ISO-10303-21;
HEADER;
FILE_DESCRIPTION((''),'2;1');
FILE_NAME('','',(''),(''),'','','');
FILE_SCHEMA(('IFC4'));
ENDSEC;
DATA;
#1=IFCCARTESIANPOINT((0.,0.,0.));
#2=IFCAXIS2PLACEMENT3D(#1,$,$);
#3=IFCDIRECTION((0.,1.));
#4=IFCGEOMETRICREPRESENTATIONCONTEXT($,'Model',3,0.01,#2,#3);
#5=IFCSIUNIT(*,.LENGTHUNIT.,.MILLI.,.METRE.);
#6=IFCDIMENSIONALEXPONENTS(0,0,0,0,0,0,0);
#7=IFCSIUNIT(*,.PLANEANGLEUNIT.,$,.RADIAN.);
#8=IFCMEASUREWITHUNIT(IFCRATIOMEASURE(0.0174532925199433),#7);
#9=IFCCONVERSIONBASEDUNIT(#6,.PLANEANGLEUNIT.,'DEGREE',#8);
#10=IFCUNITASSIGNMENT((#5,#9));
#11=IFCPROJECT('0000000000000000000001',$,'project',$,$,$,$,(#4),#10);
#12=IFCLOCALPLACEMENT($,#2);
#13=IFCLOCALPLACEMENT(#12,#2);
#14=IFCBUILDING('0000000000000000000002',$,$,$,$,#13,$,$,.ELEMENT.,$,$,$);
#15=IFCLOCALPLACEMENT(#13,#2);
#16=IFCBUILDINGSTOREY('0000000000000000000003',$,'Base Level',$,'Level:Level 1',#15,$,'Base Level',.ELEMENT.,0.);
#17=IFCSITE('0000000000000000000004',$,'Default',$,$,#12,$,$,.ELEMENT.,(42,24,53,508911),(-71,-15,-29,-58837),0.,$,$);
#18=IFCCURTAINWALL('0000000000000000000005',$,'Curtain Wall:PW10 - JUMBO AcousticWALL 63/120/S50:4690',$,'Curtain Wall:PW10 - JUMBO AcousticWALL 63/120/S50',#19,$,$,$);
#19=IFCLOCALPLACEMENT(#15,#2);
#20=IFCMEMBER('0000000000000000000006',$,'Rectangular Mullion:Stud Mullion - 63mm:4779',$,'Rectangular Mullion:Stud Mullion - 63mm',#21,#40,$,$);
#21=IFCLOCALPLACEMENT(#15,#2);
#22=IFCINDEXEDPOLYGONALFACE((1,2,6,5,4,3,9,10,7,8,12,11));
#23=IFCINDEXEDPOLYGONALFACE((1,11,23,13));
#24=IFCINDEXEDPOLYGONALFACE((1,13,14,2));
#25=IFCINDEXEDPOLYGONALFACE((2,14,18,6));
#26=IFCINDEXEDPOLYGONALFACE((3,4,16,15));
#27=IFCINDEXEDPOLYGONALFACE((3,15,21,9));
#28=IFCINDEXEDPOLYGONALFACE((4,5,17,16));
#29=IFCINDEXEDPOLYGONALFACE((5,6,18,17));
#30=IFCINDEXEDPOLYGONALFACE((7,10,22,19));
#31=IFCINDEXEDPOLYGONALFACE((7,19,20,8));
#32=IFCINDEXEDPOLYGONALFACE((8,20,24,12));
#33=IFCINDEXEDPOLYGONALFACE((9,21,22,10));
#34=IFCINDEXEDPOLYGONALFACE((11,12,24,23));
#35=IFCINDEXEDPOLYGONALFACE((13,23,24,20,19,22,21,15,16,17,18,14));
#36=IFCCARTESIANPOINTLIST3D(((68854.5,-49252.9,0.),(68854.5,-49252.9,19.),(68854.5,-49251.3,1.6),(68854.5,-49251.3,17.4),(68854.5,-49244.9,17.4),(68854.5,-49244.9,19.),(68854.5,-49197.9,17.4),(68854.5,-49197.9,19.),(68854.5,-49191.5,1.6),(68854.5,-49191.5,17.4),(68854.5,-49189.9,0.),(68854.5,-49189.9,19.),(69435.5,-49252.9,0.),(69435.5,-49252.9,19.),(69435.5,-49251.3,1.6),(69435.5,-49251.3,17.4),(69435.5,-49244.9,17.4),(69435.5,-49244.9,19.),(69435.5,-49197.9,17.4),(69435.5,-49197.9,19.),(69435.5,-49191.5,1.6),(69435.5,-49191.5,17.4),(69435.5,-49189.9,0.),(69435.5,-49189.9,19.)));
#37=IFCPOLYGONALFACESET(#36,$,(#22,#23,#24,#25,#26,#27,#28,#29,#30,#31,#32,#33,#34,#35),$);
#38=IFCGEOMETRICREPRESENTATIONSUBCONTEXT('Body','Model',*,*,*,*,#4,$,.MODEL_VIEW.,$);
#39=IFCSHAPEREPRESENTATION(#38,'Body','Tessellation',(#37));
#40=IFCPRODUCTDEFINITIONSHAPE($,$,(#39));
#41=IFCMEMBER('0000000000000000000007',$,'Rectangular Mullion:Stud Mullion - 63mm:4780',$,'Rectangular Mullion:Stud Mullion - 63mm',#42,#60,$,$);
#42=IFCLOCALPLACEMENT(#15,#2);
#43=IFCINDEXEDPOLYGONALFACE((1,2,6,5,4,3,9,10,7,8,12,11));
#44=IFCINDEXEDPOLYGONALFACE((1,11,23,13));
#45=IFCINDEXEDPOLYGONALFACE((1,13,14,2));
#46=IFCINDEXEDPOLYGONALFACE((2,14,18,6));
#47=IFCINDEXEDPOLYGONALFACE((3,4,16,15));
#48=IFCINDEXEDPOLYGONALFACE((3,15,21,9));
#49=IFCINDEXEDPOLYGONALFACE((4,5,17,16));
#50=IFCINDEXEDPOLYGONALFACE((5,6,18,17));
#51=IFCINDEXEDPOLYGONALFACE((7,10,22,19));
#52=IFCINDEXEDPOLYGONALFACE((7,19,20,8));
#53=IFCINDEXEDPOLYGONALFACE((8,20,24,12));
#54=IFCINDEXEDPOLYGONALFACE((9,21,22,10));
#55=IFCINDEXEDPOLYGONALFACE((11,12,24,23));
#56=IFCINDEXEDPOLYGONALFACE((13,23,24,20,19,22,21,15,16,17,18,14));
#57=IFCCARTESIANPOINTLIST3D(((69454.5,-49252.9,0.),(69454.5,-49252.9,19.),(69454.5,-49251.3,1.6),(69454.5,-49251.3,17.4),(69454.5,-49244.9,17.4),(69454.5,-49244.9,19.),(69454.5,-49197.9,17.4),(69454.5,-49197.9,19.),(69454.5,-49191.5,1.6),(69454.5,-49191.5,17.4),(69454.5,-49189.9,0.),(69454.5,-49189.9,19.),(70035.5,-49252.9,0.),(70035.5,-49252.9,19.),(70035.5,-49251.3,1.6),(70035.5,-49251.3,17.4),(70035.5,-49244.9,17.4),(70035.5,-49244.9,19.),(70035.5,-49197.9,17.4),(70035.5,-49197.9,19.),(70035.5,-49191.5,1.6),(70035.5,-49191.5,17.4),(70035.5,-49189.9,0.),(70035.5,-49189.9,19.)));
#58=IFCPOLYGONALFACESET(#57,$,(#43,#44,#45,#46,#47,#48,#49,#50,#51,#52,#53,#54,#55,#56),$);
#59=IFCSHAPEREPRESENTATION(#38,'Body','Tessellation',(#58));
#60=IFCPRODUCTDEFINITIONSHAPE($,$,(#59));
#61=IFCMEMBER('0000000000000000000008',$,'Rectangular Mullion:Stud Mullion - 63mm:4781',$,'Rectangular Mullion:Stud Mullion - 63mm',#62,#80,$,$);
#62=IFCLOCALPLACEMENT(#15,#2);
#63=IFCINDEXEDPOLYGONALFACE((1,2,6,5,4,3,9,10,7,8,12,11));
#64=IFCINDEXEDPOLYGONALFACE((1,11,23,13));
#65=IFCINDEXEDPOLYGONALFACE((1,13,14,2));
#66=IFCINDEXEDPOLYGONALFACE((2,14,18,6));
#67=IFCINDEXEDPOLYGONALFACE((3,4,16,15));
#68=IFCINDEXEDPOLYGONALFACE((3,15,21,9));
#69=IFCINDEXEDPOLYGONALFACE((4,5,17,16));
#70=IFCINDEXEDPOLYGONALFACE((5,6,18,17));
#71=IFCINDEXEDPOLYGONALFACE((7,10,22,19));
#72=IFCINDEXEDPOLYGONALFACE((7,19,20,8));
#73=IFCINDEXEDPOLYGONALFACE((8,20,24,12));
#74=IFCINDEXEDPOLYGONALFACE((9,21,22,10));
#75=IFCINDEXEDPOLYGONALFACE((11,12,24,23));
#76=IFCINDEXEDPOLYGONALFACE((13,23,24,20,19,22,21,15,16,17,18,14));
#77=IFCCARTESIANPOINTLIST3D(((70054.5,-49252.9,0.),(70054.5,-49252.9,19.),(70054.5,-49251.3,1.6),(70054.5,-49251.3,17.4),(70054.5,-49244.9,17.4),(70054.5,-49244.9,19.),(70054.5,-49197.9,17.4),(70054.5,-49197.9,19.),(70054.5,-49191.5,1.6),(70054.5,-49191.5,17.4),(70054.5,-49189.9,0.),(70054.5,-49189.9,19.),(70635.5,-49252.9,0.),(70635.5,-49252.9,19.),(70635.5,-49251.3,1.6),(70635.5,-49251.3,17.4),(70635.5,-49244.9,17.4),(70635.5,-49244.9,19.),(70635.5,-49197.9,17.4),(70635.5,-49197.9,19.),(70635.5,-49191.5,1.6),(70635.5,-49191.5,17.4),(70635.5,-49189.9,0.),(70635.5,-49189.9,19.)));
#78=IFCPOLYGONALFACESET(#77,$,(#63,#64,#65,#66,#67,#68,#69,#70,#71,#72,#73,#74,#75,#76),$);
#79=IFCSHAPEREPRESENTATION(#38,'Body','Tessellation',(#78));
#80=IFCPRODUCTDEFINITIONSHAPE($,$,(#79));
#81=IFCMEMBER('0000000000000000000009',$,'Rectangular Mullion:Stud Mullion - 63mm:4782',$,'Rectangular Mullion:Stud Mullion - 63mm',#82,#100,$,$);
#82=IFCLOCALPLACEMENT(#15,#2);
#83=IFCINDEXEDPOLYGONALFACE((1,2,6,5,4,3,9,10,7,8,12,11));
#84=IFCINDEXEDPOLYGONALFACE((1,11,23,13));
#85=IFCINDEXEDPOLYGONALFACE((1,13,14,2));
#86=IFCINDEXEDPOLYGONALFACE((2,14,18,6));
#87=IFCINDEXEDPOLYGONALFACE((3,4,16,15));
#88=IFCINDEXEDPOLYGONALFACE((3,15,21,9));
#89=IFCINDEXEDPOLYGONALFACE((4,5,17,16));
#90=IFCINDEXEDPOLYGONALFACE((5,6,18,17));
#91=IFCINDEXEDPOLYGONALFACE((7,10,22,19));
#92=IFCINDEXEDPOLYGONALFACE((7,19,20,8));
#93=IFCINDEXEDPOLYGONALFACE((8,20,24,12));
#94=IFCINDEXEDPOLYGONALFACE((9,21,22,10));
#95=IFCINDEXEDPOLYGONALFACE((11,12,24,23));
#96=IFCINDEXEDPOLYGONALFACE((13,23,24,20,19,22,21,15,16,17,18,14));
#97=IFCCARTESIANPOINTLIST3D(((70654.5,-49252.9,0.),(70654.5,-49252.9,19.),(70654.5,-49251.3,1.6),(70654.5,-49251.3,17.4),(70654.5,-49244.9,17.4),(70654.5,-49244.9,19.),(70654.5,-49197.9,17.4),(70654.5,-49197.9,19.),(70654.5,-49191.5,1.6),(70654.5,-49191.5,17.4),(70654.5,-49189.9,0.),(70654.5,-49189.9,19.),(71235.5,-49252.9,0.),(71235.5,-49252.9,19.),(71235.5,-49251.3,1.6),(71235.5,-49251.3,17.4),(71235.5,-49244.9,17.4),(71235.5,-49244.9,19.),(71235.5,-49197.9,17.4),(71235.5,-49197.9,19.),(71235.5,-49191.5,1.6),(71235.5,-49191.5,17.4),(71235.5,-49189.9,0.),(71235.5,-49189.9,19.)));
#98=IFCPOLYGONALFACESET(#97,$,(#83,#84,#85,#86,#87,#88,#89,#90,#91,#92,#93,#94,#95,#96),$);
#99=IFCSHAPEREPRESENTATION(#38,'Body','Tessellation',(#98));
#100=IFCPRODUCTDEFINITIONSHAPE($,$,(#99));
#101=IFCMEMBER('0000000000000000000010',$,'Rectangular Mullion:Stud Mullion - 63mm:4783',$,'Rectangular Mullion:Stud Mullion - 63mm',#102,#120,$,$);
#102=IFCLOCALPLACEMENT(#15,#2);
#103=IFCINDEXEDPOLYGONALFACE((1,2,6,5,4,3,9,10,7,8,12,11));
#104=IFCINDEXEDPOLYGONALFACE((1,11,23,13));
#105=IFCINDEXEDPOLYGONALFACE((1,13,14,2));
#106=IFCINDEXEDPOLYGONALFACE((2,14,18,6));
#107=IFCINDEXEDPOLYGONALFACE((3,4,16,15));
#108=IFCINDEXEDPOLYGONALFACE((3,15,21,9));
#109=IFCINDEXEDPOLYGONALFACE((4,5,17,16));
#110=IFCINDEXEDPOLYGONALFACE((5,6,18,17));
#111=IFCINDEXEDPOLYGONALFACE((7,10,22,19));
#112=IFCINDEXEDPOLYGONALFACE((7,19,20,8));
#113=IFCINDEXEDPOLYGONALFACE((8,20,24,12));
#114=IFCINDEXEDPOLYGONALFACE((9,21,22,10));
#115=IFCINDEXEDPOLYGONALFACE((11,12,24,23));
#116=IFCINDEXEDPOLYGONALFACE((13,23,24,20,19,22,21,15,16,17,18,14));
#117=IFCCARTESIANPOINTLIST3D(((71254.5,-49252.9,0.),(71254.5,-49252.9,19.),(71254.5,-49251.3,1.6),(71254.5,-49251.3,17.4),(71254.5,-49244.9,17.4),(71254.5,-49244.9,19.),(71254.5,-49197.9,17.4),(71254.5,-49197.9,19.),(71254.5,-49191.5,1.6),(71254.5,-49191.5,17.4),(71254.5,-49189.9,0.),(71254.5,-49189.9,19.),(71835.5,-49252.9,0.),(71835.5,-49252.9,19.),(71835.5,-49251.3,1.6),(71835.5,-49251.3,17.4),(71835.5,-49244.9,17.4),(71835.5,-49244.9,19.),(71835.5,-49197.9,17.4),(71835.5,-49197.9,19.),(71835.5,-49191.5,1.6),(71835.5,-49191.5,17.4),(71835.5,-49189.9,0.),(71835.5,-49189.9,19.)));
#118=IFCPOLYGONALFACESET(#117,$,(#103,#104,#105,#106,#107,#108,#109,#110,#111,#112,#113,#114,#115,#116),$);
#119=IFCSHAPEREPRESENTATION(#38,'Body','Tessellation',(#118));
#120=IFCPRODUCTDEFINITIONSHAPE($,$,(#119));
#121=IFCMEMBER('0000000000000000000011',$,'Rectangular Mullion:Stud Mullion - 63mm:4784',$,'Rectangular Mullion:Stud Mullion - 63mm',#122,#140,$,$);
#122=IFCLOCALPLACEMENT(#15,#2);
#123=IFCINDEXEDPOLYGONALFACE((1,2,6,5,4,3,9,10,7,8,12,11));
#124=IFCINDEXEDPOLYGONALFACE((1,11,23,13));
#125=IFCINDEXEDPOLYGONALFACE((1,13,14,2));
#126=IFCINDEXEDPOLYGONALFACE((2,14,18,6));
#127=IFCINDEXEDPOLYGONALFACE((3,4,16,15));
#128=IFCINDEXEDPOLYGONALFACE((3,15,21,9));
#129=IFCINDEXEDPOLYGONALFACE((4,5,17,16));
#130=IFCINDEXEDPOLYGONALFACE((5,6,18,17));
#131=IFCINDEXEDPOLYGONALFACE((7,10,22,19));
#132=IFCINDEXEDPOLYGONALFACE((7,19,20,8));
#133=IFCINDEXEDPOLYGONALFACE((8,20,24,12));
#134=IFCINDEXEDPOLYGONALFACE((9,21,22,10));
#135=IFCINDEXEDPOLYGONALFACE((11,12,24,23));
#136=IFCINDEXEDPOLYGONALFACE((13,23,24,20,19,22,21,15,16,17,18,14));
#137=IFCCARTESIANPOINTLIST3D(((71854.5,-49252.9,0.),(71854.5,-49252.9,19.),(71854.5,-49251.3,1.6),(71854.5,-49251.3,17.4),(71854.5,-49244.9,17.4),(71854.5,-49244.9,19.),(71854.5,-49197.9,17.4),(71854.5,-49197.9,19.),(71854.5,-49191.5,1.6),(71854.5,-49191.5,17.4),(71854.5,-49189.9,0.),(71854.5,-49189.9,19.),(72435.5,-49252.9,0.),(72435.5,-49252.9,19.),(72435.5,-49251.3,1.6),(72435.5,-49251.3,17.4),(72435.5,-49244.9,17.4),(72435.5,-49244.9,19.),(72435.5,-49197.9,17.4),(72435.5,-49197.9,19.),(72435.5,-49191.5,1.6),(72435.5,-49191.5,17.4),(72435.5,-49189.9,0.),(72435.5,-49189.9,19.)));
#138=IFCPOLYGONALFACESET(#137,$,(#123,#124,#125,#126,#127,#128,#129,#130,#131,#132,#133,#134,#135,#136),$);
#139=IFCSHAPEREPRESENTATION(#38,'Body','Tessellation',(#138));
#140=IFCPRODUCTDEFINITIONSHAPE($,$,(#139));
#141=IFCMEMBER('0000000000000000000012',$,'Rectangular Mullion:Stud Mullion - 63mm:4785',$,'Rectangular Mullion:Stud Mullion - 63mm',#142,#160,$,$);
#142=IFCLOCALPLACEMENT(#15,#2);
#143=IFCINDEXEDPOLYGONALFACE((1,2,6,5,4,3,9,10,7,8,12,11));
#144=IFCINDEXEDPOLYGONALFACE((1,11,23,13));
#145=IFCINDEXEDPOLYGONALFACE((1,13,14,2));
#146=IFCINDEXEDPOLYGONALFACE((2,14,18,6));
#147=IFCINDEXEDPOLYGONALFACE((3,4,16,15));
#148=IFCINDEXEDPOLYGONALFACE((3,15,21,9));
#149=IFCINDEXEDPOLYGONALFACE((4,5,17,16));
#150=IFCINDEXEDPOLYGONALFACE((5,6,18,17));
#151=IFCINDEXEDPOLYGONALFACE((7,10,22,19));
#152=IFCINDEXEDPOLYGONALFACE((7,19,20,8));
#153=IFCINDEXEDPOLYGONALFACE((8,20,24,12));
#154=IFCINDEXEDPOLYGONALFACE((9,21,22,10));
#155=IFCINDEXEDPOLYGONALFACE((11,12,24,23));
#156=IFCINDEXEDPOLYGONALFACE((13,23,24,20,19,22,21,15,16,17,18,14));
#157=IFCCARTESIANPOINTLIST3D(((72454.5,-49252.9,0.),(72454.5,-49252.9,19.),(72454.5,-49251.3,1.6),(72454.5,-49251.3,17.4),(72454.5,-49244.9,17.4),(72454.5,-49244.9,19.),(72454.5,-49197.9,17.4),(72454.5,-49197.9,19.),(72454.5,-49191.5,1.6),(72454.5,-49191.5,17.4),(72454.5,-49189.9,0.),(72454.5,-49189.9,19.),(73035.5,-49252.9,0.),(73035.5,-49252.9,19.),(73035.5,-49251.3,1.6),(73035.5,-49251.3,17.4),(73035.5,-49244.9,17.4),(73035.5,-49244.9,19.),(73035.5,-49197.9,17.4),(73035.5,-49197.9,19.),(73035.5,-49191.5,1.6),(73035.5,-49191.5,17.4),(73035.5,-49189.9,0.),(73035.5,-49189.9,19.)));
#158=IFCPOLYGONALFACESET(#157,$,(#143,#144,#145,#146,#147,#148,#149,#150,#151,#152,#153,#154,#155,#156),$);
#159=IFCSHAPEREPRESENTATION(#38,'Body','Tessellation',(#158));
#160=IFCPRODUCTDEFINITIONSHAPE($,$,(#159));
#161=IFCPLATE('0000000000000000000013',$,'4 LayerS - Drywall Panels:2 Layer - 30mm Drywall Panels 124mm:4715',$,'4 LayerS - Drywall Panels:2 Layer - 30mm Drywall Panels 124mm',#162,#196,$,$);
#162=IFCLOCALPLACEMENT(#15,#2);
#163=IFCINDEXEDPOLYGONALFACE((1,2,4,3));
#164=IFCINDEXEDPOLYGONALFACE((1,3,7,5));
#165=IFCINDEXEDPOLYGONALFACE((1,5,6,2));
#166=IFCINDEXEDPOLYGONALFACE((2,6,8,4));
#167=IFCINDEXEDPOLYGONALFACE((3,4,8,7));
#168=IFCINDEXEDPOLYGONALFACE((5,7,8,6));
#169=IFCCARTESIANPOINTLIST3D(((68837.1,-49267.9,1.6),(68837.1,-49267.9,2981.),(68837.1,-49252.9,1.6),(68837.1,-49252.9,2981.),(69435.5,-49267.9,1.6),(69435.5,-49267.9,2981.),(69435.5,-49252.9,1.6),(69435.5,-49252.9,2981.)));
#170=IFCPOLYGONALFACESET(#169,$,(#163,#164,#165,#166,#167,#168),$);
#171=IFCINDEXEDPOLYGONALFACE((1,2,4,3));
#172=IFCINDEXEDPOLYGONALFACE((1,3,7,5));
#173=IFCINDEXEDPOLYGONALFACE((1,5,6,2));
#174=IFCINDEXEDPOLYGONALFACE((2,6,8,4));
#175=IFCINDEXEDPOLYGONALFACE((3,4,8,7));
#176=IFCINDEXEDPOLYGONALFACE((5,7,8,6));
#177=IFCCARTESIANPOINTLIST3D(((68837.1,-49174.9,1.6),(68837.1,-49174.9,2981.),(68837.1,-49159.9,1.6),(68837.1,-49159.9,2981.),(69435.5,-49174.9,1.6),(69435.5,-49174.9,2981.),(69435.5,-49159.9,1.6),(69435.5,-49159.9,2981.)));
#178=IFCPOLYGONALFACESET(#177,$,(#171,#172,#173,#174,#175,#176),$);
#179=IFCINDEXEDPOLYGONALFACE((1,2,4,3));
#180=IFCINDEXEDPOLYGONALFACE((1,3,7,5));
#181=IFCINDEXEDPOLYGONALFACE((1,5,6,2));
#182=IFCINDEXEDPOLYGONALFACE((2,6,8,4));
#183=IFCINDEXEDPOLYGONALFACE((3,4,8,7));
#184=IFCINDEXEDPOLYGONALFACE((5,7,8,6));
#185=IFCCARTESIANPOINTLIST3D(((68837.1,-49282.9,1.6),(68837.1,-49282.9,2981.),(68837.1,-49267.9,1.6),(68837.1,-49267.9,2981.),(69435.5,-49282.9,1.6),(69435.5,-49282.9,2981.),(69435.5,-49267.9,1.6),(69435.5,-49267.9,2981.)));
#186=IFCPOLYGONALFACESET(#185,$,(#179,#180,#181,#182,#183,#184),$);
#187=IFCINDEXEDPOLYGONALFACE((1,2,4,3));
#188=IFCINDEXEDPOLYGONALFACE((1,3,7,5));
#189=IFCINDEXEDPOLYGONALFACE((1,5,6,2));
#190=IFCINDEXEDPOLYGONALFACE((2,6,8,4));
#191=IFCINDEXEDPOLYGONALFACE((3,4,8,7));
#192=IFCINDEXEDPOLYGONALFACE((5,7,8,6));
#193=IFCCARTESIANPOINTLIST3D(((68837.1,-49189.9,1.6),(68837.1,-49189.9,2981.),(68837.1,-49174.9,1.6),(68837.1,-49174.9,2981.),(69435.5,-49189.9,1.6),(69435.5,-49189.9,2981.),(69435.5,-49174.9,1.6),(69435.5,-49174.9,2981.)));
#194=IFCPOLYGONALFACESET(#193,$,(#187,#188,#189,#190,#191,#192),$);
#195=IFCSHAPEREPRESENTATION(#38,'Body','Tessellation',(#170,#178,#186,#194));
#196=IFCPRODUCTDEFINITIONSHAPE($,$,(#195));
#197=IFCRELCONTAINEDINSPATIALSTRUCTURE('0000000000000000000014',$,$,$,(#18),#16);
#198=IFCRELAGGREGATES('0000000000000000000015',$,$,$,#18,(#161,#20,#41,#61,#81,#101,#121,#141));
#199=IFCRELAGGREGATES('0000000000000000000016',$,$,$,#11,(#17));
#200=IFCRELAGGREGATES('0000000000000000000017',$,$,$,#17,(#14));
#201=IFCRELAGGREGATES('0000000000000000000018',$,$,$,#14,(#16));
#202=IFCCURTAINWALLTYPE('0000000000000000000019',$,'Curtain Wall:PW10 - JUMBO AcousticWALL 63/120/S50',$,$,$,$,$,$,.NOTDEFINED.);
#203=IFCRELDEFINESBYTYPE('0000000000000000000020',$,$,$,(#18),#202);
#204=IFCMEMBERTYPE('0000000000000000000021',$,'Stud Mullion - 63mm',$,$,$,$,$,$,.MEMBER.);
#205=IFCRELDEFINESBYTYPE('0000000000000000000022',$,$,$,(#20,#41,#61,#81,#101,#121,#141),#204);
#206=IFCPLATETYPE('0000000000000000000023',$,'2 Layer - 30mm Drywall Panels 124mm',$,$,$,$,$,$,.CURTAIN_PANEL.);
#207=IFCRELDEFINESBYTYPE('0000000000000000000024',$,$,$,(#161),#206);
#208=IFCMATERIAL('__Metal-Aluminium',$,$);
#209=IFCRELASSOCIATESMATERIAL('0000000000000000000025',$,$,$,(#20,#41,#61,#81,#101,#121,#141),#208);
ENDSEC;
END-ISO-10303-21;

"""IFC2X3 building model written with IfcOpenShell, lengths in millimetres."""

from ifc_helpers import new_model, entity, si_unit, converted_unit, direction, frame, frame_2d, origin, origin_2d_with_axis, place, context, subcontext, project, spatial, polyline, rectangle, outline, extrude, source, transform, mapped, material, type_object, type_shapes, element, aggregate, save


model = new_model("IFC2X3")

# Units and contexts
model_context = context("Model", 3, precision=0.01, world=origin(), true_north=direction((0.0, 1.0)))
body_context = subcontext(model_context, "Body", "Model", "MODEL_VIEW")
ifc_project = project(units=[si_unit("LENGTHUNIT", "METRE", prefix="MILLI"), converted_unit("PLANEANGLEUNIT", "DEGREE", entity("IfcRatioMeasure", 0.0174532925199433), si_unit("PLANEANGLEUNIT", "RADIAN"), dimensions=[0, 0, 0, 0, 0, 0, 0])], contexts=[model_context])

# Site, building, storey
site_placement = place(None, origin())
site = spatial("IfcSite", under=ifc_project, at=site_placement, Name="Default", CompositionType="ELEMENT", RefLatitude=(42, 24, 53, 508911), RefLongitude=(-71, -15, -29, -58837), RefElevation=0.0)
building_placement = place(site_placement, origin())
building = spatial("IfcBuilding", under=site, at=building_placement, CompositionType="ELEMENT")
storey_placement = place(building_placement, origin())
storey = spatial("IfcBuildingStorey", under=building, at=storey_placement, Name="Base Level", ObjectType="Level:Level 1", LongName="Base Level", CompositionType="ELEMENT", Elevation=0.0)

# Curtain wall, members, plate
curtain_wall_type = type_object("IfcCurtainWallType", Name="Curtain Wall:PW10 - JUMBO AcousticWALL 63/120/S50", PredefinedType="NOTDEFINED")
curtain_wall_placement = place(building_placement, origin())
curtain_wall = element("IfcCurtainWall", 1, at=curtain_wall_placement, inside=storey, type_object=curtain_wall_type, Name="Curtain Wall:PW10 - JUMBO AcousticWALL 63/120/S50:4690", ObjectType="Curtain Wall:PW10 - JUMBO AcousticWALL 63/120/S50")
ifc_material = material(Name="__Metal-Aluminium")
member_type_1 = type_object("IfcMemberType", Name="Stud Mullion - 63mm", PredefinedType="MEMBER")
shared_shape_1 = source(origin(), body_context, "Body", "SweptSolid", [
    extrude(outline(polyline([(23.5, -6.6), (31.5, -6.6), (31.5, 12.4), (-31.5, 12.4), (-31.5, -6.6), (-23.5, -6.6), (-23.5, -5.0), (-29.9, -5.0), (-29.9, 10.8), (29.9, 10.8), (29.9, -5.0), (23.5, -5.0), (23.5, -6.6)])), frame((-12.4, 0.0, -581.0), z_axis=(0.0, 0.0, 1.0), x_axis=(0.0, -1.0, 0.0)), (0.0, 0.0, 1.0), 581.0),
])
type_shapes(member_type_1, [shared_shape_1])
member_1_placement = place(building_placement, frame((68854.5, -49221.4, 0.0), z_axis=(-1.0, 0.0, 0.0), x_axis=(0.0, 0.0, -1.0)))
member_1 = element("IfcMember", 2, at=member_1_placement, type_object=member_type_1, material=ifc_material, Name="Rectangular Mullion:Stud Mullion - 63mm:4779", ObjectType="Rectangular Mullion:Stud Mullion - 63mm", context=body_context, shape_type="MappedRepresentation", body=[
    mapped(shared_shape_1, transform((0.0, 0.0, 0.0), scale=1.0)),
])
member_2_placement = place(building_placement, frame((69454.5, -49221.4, 0.0), z_axis=(-1.0, 0.0, 0.0), x_axis=(0.0, 0.0, -1.0)))
member_2 = element("IfcMember", 3, at=member_2_placement, type_object=member_type_1, material=ifc_material, Name="Rectangular Mullion:Stud Mullion - 63mm:4780", ObjectType="Rectangular Mullion:Stud Mullion - 63mm", context=body_context, shape_type="MappedRepresentation", body=[
    mapped(shared_shape_1, transform((0.0, 0.0, 0.0), scale=1.0)),
])
member_3_placement = place(building_placement, frame((70054.5, -49221.4, 0.0), z_axis=(-1.0, 0.0, 0.0), x_axis=(0.0, 0.0, -1.0)))
member_3 = element("IfcMember", 4, at=member_3_placement, type_object=member_type_1, material=ifc_material, Name="Rectangular Mullion:Stud Mullion - 63mm:4781", ObjectType="Rectangular Mullion:Stud Mullion - 63mm", context=body_context, shape_type="MappedRepresentation", body=[
    mapped(shared_shape_1, transform((0.0, 0.0, 0.0), scale=1.0)),
])
member_4_placement = place(building_placement, frame((70654.5, -49221.4, 0.0), z_axis=(-1.0, 0.0, 0.0), x_axis=(0.0, 0.0, -1.0)))
member_4 = element("IfcMember", 5, at=member_4_placement, type_object=member_type_1, material=ifc_material, Name="Rectangular Mullion:Stud Mullion - 63mm:4782", ObjectType="Rectangular Mullion:Stud Mullion - 63mm", context=body_context, shape_type="MappedRepresentation", body=[
    mapped(shared_shape_1, transform((0.0, 0.0, 0.0), scale=1.0)),
])
member_5_placement = place(building_placement, frame((71254.5, -49221.4, 0.0), z_axis=(-1.0, 0.0, 0.0), x_axis=(0.0, 0.0, -1.0)))
member_5 = element("IfcMember", 6, at=member_5_placement, type_object=member_type_1, material=ifc_material, Name="Rectangular Mullion:Stud Mullion - 63mm:4783", ObjectType="Rectangular Mullion:Stud Mullion - 63mm", context=body_context, shape_type="MappedRepresentation", body=[
    mapped(shared_shape_1, transform((0.0, 0.0, 0.0), scale=1.0)),
])
member_6_placement = place(building_placement, frame((71854.5, -49221.4, 0.0), z_axis=(-1.0, 0.0, 0.0), x_axis=(0.0, 0.0, -1.0)))
member_6 = element("IfcMember", 7, at=member_6_placement, type_object=member_type_1, material=ifc_material, Name="Rectangular Mullion:Stud Mullion - 63mm:4784", ObjectType="Rectangular Mullion:Stud Mullion - 63mm", context=body_context, shape_type="MappedRepresentation", body=[
    mapped(shared_shape_1, transform((0.0, 0.0, 0.0), scale=1.0)),
])
member_7_placement = place(building_placement, frame((72454.5, -49221.4, 0.0), z_axis=(-1.0, 0.0, 0.0), x_axis=(0.0, 0.0, -1.0)))
member_7 = element("IfcMember", 8, at=member_7_placement, type_object=member_type_1, material=ifc_material, Name="Rectangular Mullion:Stud Mullion - 63mm:4785", ObjectType="Rectangular Mullion:Stud Mullion - 63mm", context=body_context, shape_type="MappedRepresentation", body=[
    mapped(shared_shape_1, transform((0.0, 0.0, 0.0), scale=1.0)),
])
plate_type = type_object("IfcPlateType", Name="2 Layer - 30mm Drywall Panels 124mm", PredefinedType="CURTAIN_PANEL")
shared_shape_2 = source(origin(), body_context, "Body", "SweptSolid", [
    extrude(rectangle(XDim=15.0, YDim=598.4, at=origin_2d_with_axis()), frame((0.0, -39.0, 0.0), z_axis=(0.0, 0.0, 1.0), x_axis=(0.0, 1.0, 0.0)), (0.0, 0.0, 1.0), 2979.4),
    extrude(rectangle(XDim=15.0, YDim=598.4, at=origin_2d_with_axis()), frame((0.0, 54.0, 0.0), z_axis=(0.0, 0.0, 1.0), x_axis=(0.0, 1.0, 0.0)), (0.0, 0.0, 1.0), 2979.4),
    extrude(rectangle(XDim=598.4, YDim=15.0, at=frame_2d((0.0, 0.0), x_axis=(1.0, 0.0))), frame((0.0, -54.0, 0.0), z_axis=(0.0, 0.0, 1.0), x_axis=(-1.0, 0.0, 0.0)), (0.0, 0.0, 1.0), 2979.4),
    extrude(rectangle(XDim=15.0, YDim=598.4, at=frame_2d((0.0, 0.0), x_axis=(1.0, 0.0))), frame((0.0, 39.0, 0.0), z_axis=(0.0, 0.0, 1.0), x_axis=(0.0, 1.0, 0.0)), (0.0, 0.0, 1.0), 2979.4),
])
type_shapes(plate_type, [shared_shape_2])
plate_1_placement = place(curtain_wall_placement, frame((69136.3, -49221.4, 1.6)))
plate_1 = element("IfcPlate", 9, at=plate_1_placement, type_object=plate_type, Name="4 LayerS - Drywall Panels:2 Layer - 30mm Drywall Panels 124mm:4715", ObjectType="4 LayerS - Drywall Panels:2 Layer - 30mm Drywall Panels 124mm", context=body_context, shape_type="MappedRepresentation", body=[
    mapped(shared_shape_2, transform((0.0, 0.0, 0.0), scale=1.0)),
])
aggregate(curtain_wall, [plate_1, member_1, member_2, member_3, member_4, member_5, member_6, member_7])

save(model, "model.ifc")
